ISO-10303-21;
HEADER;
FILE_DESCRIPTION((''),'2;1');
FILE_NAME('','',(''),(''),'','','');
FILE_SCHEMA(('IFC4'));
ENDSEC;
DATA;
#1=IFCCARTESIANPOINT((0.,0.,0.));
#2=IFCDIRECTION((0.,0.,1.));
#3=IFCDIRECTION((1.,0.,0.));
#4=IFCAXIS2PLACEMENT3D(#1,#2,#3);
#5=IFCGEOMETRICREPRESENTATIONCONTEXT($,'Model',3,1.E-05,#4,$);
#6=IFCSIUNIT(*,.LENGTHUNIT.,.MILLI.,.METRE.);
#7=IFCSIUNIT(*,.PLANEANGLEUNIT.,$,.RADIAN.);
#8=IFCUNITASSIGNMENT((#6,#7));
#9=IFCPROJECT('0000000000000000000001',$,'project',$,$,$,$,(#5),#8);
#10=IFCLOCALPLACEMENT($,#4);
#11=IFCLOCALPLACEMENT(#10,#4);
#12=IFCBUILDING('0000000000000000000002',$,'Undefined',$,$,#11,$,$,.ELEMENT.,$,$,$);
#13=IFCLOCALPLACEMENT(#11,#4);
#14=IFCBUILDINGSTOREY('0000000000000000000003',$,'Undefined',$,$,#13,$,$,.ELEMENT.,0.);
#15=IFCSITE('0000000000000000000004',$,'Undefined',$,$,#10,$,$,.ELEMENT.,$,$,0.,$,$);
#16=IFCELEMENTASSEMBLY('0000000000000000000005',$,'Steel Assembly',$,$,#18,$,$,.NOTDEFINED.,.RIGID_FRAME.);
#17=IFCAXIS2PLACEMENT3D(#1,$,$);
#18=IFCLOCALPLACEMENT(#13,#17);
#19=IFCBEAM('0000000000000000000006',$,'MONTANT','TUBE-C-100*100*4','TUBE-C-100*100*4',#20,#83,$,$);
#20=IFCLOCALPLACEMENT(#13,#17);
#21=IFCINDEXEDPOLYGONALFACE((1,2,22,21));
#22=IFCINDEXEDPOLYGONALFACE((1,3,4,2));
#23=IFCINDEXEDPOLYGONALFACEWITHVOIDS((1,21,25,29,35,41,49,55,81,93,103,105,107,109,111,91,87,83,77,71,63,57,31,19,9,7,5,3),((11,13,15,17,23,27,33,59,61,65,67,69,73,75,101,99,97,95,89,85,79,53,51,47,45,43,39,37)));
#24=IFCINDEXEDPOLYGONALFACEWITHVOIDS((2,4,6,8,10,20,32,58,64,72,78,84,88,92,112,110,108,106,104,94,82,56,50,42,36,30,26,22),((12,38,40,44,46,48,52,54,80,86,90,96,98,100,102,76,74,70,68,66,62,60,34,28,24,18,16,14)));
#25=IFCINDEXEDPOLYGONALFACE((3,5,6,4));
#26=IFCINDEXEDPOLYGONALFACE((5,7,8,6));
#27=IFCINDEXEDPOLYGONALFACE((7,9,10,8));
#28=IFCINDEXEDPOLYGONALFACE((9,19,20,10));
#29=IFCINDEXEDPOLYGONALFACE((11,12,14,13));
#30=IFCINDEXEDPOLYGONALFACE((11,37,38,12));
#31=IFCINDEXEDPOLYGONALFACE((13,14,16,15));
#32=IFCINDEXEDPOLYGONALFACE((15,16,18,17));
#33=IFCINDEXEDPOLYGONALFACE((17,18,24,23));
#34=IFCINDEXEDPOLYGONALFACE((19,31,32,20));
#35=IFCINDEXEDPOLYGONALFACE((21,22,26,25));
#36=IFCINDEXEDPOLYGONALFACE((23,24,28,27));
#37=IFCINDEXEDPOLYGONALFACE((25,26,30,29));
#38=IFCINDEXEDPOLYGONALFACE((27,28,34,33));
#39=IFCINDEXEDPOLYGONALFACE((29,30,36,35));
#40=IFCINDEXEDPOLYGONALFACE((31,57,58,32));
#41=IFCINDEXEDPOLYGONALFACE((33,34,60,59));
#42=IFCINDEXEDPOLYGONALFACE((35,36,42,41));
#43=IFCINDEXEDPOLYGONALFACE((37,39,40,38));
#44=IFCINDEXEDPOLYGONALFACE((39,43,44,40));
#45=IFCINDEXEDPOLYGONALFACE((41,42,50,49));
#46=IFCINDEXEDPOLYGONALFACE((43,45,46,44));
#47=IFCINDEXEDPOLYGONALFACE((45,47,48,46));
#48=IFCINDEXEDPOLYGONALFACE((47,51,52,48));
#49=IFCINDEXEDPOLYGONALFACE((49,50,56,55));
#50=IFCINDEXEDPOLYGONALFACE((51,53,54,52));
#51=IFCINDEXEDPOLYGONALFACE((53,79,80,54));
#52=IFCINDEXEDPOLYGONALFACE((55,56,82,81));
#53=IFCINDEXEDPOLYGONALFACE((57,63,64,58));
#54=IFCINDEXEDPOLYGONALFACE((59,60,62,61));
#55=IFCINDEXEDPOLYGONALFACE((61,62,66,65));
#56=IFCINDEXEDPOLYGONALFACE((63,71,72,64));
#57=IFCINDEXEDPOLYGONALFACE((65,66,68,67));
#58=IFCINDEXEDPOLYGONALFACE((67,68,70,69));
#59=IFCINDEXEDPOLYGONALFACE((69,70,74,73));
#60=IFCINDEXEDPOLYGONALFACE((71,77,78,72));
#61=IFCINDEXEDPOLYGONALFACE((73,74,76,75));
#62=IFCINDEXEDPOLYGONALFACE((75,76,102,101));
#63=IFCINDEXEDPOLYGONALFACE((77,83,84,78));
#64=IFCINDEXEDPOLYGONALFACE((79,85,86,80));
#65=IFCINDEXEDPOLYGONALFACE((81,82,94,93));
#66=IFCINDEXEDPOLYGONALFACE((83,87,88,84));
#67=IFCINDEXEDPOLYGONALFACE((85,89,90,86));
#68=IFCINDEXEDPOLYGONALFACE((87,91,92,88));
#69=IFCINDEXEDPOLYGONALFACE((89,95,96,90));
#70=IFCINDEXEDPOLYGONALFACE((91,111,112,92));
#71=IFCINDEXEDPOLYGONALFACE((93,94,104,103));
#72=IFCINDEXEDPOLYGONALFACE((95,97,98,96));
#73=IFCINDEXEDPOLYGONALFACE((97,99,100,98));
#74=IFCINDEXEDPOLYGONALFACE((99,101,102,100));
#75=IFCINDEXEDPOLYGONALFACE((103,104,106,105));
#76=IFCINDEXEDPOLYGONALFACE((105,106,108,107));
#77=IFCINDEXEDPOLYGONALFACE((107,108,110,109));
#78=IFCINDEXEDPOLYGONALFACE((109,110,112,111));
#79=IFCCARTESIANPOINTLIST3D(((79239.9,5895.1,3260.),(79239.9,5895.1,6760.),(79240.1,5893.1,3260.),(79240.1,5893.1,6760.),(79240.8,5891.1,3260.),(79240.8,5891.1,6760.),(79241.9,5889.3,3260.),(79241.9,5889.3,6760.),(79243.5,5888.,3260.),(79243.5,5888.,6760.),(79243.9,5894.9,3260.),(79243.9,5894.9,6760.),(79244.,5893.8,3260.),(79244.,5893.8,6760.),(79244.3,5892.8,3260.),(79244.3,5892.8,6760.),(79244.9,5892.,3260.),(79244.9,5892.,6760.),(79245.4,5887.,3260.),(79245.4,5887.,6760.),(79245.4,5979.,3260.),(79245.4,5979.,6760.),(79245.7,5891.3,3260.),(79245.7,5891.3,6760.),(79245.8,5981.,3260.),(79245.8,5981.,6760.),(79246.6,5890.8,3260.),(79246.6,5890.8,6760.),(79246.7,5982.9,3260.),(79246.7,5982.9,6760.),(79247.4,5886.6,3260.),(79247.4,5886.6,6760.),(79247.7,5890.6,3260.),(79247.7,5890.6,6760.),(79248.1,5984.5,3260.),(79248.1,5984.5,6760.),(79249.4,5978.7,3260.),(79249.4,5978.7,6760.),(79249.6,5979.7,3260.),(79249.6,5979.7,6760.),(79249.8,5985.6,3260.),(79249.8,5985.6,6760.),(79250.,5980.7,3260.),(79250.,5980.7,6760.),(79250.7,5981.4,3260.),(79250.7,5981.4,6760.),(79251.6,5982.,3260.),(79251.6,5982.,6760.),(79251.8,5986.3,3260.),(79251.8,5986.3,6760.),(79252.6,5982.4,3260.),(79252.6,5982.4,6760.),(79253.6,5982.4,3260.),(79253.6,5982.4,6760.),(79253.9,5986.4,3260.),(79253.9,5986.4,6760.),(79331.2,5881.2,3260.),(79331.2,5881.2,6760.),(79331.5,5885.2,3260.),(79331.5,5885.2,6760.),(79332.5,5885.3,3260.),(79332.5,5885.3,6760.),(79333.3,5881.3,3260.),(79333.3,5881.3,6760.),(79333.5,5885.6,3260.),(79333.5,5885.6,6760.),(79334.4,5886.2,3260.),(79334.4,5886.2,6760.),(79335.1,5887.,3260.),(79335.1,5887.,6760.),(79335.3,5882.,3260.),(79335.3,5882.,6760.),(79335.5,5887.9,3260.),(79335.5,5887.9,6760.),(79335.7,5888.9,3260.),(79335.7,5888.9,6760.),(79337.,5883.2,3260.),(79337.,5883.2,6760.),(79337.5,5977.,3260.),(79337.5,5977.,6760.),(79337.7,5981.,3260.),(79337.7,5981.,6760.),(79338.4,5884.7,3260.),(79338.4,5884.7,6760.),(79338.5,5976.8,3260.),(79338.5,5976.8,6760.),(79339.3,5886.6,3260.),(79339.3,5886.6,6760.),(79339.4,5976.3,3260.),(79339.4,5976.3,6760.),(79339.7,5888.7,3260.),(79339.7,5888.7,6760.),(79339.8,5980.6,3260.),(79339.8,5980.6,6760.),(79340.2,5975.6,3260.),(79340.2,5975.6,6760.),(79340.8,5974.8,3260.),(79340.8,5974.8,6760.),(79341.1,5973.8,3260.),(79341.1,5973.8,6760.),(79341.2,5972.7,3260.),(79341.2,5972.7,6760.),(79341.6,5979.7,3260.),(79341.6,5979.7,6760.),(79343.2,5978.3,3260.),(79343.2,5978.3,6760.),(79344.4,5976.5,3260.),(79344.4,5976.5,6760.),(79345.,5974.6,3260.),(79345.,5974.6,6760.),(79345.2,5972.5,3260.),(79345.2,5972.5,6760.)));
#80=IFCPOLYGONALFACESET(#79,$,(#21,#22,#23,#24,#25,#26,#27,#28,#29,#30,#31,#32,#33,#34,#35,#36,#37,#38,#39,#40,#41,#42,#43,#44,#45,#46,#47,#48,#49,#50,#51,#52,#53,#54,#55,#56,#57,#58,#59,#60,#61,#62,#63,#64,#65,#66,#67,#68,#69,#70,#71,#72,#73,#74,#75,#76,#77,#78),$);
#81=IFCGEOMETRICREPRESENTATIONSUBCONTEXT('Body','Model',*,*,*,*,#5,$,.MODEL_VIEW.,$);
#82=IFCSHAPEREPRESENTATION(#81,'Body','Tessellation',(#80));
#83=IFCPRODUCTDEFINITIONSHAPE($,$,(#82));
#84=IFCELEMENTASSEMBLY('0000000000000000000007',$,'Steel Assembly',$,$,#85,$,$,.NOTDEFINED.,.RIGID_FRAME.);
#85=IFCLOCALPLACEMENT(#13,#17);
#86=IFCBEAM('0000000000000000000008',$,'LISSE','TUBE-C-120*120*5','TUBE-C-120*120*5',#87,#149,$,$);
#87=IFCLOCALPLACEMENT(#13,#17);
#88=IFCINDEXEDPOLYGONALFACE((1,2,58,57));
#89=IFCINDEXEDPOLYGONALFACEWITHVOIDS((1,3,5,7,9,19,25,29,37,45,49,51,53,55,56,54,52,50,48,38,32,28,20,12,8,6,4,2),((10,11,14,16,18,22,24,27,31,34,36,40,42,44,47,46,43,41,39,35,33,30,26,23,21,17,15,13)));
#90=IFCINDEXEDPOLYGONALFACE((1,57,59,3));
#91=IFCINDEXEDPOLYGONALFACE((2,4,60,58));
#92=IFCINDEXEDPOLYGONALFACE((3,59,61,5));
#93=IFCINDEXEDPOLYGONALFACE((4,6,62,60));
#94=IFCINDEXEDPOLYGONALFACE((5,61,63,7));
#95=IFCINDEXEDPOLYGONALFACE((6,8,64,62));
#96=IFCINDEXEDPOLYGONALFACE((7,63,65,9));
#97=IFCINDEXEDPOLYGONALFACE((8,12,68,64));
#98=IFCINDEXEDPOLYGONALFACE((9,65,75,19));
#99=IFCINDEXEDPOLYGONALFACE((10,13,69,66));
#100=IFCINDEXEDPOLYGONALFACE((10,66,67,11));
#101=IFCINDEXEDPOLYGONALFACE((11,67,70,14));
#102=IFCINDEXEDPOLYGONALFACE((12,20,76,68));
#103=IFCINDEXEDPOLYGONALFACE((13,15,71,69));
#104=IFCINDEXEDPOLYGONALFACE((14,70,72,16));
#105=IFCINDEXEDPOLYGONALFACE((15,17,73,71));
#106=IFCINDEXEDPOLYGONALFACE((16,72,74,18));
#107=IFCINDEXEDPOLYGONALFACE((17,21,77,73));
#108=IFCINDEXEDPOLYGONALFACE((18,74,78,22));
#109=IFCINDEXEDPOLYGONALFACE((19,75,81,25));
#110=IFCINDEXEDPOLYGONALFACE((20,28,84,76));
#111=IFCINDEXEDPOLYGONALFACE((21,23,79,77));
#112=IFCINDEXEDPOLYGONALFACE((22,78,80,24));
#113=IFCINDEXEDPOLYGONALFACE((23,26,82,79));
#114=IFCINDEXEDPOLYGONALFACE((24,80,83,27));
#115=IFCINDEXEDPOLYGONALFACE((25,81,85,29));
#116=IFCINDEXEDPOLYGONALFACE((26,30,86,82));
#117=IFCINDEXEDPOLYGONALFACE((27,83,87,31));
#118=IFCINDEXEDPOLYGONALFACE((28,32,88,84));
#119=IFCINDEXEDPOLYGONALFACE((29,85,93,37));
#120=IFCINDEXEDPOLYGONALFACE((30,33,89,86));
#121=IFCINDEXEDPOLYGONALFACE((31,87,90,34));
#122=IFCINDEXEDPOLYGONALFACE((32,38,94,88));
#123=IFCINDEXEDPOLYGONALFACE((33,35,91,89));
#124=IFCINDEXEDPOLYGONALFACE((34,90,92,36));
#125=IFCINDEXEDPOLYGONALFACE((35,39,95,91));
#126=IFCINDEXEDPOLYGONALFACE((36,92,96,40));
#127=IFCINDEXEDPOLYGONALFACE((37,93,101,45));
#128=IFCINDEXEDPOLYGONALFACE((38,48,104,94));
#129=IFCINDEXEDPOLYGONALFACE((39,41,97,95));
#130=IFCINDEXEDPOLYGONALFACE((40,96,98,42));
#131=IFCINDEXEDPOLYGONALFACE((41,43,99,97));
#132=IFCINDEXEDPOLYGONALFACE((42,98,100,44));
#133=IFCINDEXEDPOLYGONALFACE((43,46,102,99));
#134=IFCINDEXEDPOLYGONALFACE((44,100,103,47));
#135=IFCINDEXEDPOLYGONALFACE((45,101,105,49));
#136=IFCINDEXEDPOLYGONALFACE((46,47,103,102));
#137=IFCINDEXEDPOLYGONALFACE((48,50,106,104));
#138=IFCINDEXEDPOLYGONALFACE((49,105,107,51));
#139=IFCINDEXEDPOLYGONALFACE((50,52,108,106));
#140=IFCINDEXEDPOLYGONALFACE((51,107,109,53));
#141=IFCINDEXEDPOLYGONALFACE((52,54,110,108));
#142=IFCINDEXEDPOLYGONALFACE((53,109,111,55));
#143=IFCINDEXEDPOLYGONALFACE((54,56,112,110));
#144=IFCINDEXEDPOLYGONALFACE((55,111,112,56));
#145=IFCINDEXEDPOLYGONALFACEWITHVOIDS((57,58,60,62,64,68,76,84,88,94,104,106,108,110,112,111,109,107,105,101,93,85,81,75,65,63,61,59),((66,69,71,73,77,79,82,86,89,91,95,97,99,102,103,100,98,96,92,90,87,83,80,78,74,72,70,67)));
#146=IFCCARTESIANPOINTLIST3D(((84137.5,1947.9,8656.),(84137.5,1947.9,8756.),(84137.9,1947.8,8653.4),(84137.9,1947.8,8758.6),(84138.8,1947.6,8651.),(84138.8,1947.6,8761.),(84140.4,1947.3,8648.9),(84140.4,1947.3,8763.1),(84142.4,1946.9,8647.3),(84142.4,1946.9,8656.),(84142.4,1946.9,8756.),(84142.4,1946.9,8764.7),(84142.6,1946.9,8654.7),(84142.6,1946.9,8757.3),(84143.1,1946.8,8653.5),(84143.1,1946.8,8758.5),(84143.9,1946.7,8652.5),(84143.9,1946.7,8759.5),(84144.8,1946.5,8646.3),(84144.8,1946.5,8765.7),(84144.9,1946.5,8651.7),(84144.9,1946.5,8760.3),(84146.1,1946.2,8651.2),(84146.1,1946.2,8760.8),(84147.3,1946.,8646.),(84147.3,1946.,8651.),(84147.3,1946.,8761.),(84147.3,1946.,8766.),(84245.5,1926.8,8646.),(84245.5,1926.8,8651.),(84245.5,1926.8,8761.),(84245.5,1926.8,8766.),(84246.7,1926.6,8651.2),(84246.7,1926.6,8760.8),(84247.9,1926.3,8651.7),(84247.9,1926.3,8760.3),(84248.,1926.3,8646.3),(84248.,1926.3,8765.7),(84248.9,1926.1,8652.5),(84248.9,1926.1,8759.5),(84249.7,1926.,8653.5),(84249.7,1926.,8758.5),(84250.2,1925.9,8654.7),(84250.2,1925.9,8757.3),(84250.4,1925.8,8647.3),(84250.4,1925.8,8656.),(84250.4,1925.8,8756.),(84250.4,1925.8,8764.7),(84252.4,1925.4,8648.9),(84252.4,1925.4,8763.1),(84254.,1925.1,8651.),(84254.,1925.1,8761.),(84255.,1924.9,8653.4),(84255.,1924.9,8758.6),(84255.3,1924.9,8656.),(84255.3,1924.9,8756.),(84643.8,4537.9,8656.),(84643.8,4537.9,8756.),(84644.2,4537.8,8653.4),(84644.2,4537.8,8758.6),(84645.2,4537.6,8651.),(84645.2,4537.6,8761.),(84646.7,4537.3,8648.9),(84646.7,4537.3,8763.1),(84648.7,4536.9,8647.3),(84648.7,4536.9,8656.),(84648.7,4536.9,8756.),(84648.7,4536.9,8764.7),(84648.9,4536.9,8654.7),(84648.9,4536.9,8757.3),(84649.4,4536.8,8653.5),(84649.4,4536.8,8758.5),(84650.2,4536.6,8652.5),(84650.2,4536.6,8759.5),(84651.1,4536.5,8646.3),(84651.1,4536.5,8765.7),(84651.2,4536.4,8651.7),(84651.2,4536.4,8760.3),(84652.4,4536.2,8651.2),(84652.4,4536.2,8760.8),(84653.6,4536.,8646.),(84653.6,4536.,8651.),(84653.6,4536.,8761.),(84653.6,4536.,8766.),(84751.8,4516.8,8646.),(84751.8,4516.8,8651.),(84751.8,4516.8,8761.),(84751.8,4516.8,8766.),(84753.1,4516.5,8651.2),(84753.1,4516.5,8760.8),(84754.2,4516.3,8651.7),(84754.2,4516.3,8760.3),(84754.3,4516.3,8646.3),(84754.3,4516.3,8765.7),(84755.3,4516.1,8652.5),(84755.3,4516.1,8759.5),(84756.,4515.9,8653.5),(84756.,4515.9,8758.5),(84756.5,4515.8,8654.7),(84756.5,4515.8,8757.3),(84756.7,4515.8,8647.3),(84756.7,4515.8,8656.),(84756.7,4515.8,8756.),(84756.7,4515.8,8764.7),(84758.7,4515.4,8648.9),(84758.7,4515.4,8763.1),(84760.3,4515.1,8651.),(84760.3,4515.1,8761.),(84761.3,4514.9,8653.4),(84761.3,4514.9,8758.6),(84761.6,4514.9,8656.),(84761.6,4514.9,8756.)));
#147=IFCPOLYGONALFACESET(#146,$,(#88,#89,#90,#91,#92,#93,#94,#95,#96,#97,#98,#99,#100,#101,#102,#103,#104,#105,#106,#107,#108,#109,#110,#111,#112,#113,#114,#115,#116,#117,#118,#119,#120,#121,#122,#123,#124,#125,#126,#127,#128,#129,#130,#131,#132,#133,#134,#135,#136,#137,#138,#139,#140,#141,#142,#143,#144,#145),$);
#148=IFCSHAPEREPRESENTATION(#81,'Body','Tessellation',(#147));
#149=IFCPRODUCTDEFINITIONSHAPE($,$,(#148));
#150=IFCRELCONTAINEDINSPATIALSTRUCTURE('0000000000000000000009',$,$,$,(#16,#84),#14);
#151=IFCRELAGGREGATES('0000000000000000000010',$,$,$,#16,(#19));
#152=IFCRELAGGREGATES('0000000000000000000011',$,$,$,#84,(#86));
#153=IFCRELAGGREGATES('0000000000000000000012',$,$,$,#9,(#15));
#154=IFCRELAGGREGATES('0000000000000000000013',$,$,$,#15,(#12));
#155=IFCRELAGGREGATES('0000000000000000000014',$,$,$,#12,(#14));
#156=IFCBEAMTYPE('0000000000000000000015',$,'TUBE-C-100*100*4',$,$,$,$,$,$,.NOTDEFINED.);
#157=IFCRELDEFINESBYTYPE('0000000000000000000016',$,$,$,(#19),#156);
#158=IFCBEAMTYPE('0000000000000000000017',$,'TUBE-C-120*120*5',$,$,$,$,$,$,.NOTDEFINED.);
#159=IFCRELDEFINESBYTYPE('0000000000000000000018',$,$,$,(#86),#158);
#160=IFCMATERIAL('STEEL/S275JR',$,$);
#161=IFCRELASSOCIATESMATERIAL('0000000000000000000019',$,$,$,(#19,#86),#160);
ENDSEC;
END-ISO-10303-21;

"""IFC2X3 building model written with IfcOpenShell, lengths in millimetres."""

from ifc_helpers import new_model, si_unit, frame, origin_with_axes, origin_2d_with_axis, place, context, subcontext, project, spatial, hollow_rectangle, extrude, material, type_object, element, aggregate, save


model = new_model("IFC2X3")

# Units and contexts
model_context = context("Model", 3, precision=1e-05, world=origin_with_axes())
body_context = subcontext(model_context, "Body", "Model", "MODEL_VIEW")
ifc_project = project(units=[si_unit("LENGTHUNIT", "METRE", prefix="MILLI"), si_unit("PLANEANGLEUNIT", "RADIAN")], contexts=[model_context])

# Site, building, storey
site_placement = place(None, origin_with_axes())
site = spatial("IfcSite", under=ifc_project, at=site_placement, Name="Undefined", CompositionType="ELEMENT", RefElevation=0.0)
building_placement = place(site_placement, origin_with_axes())
building = spatial("IfcBuilding", under=site, at=building_placement, Name="Undefined", CompositionType="ELEMENT")
storey_placement = place(building_placement, origin_with_axes())
storey = spatial("IfcBuildingStorey", under=building, at=storey_placement, Name="Undefined", CompositionType="ELEMENT", Elevation=0.0)

# Element assemblies, beams
ifc_material_1 = material(Name="STEEL/S275JR")
beam_type_1 = type_object("IfcBeamType", Name="TUBE-C-100*100*4", PredefinedType="NOTDEFINED")
assembly_1_placement = place(storey_placement, origin_with_axes())
assembly_1 = element("IfcElementAssembly", 1, at=assembly_1_placement, inside=storey, Name="Steel Assembly", AssemblyPlace="NOTDEFINED", PredefinedType="RIGID_FRAME")
beam_1_placement = place(assembly_1_placement, frame((79292.6, 5933.8, 6760.0), z_axis=(-0.997897, 0.064812, 0.0), x_axis=(0.0, 0.0, -1.0)))
beam_1 = element("IfcBeam", 2, at=beam_1_placement, type_object=beam_type_1, material=ifc_material_1, Name="MONTANT", Description="TUBE-C-100*100*4", ObjectType="TUBE-C-100*100*4", context=body_context, shape_type="SweptSolid", body=[
    extrude(hollow_rectangle(XDim=100.0, YDim=100.0, WallThickness=4.0, InnerFilletRadius=4.0, OuterFilletRadius=8.0, at=origin_2d_with_axis()), frame((3500.0, 0.0, 0.0), z_axis=(-1.0, 0.0, 0.0), x_axis=(0.0, -1.0, 0.0)), (0.0, 0.0, 1.0), 3500.0),
])
aggregate(assembly_1, [beam_1])
beam_type_2 = type_object("IfcBeamType", Name="TUBE-C-120*120*5", PredefinedType="NOTDEFINED")
assembly_2_placement = place(storey_placement, origin_with_axes())
assembly_2 = element("IfcElementAssembly", 3, at=assembly_2_placement, inside=storey, Name="Steel Assembly", AssemblyPlace="NOTDEFINED", PredefinedType="RIGID_FRAME")
beam_2_placement = place(assembly_2_placement, frame((84702.7, 4526.4, 8706.0), z_axis=(0.981422, -0.191859, 0.0), x_axis=(-0.19186, -0.981422, 0.0)))
beam_2 = element("IfcBeam", 4, at=beam_2_placement, type_object=beam_type_2, material=ifc_material_1, Name="LISSE", Description="TUBE-C-120*120*5", ObjectType="TUBE-C-120*120*5", context=body_context, shape_type="SweptSolid", body=[
    extrude(hollow_rectangle(XDim=120.0, YDim=120.0, WallThickness=5.0, InnerFilletRadius=5.0, OuterFilletRadius=10.0, at=origin_2d_with_axis()), frame((2639.0, 0.0, 0.0), z_axis=(-1.0, 0.0, 0.0), x_axis=(0.0, -1.0, 0.0)), (0.0, 0.0, 1.0), 2639.0),
])
aggregate(assembly_2, [beam_2])

save(model, "model.ifc")
